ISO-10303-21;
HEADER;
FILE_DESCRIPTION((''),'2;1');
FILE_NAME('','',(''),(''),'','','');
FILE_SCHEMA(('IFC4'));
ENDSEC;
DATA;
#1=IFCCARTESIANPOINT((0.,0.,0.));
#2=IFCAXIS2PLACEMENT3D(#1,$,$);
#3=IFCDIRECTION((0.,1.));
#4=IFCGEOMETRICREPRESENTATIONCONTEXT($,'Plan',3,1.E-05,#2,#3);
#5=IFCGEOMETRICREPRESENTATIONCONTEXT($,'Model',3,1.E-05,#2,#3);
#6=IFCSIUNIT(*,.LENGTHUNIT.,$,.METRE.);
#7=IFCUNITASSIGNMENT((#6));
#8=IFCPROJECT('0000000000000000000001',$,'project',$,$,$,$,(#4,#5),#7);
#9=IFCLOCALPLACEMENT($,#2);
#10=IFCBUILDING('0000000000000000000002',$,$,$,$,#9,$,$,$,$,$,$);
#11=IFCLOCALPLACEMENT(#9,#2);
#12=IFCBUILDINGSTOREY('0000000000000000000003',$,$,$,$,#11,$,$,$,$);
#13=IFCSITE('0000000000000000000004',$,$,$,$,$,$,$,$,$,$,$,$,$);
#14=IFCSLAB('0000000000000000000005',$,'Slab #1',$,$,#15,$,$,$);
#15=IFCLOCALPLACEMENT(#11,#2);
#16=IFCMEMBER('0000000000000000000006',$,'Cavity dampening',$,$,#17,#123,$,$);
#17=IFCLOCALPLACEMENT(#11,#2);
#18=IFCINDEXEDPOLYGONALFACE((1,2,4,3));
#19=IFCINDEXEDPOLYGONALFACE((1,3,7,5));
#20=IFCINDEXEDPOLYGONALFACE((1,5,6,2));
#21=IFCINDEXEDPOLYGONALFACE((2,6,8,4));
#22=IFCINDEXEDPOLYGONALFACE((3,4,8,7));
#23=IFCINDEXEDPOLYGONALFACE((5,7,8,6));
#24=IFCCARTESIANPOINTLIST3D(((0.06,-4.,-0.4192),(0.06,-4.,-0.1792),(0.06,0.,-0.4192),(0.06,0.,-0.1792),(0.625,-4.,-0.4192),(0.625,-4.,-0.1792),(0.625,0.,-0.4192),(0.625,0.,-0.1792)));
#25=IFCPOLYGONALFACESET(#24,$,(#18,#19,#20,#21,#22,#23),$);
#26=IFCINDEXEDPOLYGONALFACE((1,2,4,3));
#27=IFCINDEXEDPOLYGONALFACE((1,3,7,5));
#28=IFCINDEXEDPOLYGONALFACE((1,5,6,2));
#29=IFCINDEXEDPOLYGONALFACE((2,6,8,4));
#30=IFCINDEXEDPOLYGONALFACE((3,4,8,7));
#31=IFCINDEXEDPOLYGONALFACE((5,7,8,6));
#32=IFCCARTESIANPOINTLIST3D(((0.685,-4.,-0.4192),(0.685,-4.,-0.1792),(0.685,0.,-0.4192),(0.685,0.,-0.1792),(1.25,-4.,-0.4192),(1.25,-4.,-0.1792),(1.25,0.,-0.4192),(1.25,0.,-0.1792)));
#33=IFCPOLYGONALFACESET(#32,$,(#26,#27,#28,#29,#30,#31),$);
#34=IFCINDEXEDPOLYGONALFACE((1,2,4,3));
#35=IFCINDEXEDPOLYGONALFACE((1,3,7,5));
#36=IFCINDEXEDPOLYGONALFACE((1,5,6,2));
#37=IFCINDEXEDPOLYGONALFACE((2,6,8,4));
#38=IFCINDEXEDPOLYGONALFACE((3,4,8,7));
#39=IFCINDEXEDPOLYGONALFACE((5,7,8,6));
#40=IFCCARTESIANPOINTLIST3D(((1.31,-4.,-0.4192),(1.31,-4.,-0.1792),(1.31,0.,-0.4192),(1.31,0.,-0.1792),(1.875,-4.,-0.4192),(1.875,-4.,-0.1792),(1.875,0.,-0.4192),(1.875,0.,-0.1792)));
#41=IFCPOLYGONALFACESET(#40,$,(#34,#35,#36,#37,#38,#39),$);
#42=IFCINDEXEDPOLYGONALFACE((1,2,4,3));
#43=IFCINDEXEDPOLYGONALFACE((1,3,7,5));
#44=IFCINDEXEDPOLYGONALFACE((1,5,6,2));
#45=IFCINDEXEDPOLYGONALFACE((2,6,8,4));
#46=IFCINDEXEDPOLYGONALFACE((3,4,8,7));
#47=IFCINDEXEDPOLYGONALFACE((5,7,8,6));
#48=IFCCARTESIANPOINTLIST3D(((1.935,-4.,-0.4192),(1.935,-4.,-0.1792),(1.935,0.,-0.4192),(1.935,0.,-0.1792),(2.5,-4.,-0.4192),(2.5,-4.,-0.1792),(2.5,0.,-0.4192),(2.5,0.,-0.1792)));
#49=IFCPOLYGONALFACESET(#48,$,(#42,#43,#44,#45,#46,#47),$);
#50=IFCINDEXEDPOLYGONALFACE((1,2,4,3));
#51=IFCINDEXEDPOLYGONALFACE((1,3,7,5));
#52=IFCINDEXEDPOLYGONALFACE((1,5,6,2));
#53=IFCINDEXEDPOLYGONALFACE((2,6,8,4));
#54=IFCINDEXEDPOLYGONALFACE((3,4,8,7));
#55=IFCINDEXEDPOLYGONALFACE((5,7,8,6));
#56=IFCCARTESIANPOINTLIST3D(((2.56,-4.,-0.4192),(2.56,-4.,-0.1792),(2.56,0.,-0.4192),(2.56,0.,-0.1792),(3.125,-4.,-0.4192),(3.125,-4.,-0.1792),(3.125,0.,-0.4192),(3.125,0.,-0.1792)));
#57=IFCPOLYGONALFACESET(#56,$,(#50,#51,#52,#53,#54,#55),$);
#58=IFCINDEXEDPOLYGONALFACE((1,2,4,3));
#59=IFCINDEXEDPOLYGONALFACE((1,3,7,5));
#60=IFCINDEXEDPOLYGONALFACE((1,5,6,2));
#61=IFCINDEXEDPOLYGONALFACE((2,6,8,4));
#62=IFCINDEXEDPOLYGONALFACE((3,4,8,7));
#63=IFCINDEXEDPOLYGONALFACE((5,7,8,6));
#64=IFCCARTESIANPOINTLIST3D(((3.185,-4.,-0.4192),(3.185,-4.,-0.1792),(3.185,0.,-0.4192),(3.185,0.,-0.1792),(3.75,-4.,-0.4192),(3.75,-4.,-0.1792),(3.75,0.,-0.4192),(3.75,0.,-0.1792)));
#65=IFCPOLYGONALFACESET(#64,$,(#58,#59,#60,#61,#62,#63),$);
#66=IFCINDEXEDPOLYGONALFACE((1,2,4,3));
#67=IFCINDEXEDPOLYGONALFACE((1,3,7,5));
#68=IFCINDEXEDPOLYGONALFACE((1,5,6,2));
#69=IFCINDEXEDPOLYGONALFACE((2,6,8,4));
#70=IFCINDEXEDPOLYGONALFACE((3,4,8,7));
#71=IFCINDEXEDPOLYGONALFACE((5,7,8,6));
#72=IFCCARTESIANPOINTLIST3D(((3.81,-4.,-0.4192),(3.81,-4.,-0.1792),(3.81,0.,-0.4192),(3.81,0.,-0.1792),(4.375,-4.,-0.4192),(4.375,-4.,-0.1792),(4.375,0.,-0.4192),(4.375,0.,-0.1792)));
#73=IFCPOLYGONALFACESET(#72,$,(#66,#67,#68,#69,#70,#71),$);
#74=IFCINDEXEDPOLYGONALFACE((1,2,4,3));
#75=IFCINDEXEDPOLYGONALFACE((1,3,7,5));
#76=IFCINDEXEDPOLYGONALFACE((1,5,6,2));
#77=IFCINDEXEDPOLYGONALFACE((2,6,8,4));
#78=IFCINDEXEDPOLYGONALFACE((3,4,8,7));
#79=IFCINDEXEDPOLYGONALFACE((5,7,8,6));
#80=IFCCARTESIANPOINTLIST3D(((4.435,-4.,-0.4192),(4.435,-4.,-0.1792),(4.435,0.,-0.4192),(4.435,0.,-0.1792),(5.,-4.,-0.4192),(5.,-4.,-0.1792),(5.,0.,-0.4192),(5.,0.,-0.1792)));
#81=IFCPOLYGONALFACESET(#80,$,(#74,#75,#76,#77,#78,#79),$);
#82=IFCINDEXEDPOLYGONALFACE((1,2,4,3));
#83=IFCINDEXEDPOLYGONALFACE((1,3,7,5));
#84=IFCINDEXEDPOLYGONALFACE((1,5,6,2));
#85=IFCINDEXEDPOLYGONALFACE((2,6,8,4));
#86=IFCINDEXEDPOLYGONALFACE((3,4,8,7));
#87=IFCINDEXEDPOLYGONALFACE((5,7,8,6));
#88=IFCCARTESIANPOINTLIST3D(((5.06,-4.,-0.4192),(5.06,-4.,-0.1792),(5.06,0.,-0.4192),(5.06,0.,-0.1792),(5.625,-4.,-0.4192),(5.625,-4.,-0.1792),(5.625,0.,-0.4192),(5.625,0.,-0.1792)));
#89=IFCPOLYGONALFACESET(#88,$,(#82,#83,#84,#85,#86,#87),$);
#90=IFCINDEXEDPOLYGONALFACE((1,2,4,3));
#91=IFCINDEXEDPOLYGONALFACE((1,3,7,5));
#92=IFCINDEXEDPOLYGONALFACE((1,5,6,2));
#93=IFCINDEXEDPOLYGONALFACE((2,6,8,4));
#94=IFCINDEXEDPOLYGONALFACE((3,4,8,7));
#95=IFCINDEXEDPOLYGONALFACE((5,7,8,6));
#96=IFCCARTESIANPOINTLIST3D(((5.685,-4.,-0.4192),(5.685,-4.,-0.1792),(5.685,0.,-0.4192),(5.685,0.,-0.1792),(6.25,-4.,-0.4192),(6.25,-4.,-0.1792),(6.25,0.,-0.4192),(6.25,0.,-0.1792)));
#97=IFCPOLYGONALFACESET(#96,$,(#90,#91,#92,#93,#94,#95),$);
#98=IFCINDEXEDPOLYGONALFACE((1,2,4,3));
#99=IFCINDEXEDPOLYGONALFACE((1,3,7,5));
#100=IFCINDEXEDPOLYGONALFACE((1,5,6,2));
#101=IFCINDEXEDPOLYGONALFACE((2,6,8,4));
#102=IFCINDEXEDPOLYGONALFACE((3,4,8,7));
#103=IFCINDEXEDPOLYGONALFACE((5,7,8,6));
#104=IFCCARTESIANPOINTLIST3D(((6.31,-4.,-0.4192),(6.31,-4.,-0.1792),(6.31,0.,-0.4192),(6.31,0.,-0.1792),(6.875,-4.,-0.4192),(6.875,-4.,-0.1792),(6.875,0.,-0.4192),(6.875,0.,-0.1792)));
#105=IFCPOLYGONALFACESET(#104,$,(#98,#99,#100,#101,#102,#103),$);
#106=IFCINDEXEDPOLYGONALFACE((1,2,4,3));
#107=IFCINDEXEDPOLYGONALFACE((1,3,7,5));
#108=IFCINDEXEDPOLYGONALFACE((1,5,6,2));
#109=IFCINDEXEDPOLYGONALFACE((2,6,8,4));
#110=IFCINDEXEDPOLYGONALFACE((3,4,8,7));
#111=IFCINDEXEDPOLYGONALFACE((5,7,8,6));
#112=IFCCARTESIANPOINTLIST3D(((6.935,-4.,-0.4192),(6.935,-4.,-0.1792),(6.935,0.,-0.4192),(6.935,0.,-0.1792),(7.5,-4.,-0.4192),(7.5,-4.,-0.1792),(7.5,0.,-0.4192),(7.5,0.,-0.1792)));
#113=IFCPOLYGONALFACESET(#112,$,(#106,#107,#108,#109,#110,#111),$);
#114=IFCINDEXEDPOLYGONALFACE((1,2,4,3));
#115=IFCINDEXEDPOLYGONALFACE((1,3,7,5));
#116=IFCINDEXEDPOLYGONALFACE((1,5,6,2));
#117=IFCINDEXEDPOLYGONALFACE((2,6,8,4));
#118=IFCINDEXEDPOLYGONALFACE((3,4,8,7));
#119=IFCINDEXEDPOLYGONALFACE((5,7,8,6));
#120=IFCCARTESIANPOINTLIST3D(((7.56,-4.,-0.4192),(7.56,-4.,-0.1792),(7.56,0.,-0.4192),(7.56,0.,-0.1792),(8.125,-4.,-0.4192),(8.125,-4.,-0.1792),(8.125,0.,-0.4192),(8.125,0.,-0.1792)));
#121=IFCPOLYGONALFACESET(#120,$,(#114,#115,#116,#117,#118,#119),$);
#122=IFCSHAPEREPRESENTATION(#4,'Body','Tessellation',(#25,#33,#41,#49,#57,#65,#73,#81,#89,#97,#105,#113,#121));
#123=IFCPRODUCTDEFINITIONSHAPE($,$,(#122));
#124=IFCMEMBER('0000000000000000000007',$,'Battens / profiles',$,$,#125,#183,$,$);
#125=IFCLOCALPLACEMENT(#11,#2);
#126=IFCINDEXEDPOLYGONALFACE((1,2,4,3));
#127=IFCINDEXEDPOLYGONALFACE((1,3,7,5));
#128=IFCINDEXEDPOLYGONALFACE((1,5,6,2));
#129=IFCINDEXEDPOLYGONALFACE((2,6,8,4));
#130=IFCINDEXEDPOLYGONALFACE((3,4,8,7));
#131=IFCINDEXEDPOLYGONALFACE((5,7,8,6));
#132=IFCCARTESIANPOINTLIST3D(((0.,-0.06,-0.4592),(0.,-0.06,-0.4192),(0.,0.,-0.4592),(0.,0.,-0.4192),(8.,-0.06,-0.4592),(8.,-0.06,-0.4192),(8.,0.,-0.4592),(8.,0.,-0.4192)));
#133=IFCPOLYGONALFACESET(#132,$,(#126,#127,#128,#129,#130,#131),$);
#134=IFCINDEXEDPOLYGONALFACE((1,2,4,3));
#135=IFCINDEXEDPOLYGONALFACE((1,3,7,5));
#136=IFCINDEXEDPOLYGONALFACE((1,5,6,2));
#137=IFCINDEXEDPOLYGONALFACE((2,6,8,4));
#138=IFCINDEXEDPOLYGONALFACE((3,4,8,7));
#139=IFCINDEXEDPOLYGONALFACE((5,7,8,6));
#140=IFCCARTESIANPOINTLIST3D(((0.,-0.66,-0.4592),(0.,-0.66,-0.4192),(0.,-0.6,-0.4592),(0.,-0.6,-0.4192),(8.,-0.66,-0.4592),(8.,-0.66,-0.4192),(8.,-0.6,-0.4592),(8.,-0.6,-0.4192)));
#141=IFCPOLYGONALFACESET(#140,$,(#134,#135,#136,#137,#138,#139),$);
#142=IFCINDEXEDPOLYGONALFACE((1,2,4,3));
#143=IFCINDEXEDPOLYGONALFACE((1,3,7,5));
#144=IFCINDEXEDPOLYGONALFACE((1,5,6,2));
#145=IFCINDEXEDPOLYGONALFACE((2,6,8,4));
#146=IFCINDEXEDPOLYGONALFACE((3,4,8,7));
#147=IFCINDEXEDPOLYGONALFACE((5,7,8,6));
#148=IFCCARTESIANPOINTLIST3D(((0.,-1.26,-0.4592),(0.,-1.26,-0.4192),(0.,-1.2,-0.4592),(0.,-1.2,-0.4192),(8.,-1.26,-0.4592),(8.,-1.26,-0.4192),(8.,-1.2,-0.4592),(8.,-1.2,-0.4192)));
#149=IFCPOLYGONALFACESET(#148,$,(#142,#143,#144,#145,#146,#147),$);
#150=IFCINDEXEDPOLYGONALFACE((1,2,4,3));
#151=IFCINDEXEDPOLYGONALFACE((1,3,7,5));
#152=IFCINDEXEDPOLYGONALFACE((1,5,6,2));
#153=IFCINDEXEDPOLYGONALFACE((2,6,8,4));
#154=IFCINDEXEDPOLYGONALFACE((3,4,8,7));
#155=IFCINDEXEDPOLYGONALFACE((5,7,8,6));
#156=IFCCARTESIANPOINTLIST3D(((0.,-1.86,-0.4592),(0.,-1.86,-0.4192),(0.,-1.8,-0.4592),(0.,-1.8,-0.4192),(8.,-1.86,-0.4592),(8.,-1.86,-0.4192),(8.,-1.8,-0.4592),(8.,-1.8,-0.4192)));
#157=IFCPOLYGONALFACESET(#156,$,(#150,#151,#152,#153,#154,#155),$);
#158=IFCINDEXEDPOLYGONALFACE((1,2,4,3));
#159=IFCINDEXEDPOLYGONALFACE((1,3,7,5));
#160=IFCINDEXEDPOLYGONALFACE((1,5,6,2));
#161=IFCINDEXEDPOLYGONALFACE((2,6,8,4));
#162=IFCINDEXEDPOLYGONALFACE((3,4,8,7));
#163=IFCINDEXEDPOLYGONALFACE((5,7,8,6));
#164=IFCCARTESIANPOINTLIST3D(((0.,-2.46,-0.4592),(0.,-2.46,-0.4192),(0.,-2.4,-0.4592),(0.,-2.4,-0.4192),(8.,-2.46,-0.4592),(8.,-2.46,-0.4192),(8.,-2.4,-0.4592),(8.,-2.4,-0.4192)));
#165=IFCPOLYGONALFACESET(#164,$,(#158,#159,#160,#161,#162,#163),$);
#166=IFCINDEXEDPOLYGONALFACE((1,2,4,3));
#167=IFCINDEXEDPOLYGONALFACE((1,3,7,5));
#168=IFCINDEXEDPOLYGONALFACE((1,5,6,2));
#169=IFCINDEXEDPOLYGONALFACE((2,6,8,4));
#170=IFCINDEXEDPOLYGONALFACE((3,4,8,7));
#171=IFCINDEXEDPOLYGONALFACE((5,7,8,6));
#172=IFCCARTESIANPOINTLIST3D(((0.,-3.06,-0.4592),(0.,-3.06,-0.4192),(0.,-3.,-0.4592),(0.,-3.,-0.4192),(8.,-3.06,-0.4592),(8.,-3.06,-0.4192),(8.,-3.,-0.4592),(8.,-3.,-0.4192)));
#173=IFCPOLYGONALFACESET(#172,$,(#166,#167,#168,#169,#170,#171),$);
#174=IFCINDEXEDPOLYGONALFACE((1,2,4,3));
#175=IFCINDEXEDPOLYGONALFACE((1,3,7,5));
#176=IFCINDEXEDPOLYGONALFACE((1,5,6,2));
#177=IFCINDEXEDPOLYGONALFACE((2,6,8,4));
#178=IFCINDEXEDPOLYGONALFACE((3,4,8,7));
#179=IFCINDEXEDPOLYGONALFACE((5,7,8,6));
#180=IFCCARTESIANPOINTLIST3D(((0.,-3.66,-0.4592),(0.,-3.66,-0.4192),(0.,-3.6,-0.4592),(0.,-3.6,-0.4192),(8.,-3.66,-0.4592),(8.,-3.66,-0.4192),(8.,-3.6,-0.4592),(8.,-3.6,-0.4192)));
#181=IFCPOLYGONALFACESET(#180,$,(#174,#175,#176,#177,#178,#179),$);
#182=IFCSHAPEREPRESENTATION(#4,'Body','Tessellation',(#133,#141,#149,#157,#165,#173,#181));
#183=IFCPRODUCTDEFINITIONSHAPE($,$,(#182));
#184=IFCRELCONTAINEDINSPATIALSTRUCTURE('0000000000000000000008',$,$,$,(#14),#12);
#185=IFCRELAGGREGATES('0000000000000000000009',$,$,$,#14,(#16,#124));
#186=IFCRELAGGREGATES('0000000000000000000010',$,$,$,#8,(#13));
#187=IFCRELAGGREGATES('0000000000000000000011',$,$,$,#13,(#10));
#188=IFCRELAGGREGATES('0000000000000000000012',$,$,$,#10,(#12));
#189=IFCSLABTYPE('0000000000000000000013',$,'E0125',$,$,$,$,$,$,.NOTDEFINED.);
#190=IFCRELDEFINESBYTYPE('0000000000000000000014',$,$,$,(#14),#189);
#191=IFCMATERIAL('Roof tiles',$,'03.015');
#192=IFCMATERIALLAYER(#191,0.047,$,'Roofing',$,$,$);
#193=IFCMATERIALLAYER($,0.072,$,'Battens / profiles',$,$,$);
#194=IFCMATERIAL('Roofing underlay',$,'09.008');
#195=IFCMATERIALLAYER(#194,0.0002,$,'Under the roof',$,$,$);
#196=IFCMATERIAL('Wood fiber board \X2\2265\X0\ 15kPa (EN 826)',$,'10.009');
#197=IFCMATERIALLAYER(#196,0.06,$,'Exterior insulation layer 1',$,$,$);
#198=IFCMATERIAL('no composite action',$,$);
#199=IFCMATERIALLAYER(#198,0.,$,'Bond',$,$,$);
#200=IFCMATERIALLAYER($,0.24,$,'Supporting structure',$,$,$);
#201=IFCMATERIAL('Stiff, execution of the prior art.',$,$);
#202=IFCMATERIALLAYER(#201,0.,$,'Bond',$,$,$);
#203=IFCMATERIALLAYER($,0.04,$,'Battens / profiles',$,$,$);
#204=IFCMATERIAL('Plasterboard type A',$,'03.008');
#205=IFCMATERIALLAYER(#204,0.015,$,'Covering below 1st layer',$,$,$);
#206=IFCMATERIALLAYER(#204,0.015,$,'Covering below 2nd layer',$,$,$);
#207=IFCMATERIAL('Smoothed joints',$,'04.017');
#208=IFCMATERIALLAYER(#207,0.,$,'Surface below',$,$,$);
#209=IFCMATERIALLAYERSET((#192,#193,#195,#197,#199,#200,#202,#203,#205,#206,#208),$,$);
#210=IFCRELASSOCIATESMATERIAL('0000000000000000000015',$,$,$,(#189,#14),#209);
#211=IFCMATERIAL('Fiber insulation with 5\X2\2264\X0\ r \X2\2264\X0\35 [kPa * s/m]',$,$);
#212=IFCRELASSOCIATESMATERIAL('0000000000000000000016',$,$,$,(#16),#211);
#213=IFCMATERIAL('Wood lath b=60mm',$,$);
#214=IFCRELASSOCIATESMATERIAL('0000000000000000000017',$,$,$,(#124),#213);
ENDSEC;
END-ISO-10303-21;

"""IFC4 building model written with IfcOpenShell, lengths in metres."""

from ifc_helpers import new_model, si_unit, direction, frame, frame_2d, origin, place, context, project, spatial, rectangle, extrude, material, layer, layer_set, type_object, element, aggregate, save


model = new_model("IFC4")

# Units and contexts
plan_context = context("Plan", 3, precision=1e-05, world=origin(), true_north=direction((0.0, 1.0)))
model_context = context("Model", 3, precision=1e-05, world=origin(), true_north=direction((0.0, 1.0)))
ifc_project = project(units=[si_unit("LENGTHUNIT", "METRE")], contexts=[plan_context, model_context])

# Site, building, storey
site = spatial("IfcSite", under=ifc_project)
building_placement = place(None, origin())
building = spatial("IfcBuilding", under=site, at=building_placement)
storey_placement = place(building_placement, origin())
storey = spatial("IfcBuildingStorey", under=building, at=storey_placement)

# Slab, members
ifc_material_1 = material(Name="Roof tiles", Category="03.015")
ifc_layer_1 = layer(ifc_material_1, 0.047, Name="Roofing")
ifc_layer_2 = layer(None, 0.072, Name="Battens / profiles")
ifc_material_2 = material(Name="Roofing underlay", Category="09.008")
ifc_layer_3 = layer(ifc_material_2, 0.0002, Name="Under the roof")
ifc_material_3 = material(Name="Wood fiber board ≥ 15kPa (EN 826)", Category="10.009")
ifc_layer_4 = layer(ifc_material_3, 0.06, Name="Exterior insulation layer 1")
ifc_material_4 = material(Name="no composite action")
ifc_layer_5 = layer(ifc_material_4, 0.0, Name="Bond")
ifc_layer_6 = layer(None, 0.24, Name="Supporting structure")
ifc_material_5 = material(Name="Stiff, execution of the prior art.")
ifc_layer_7 = layer(ifc_material_5, 0.0, Name="Bond")
ifc_layer_8 = layer(None, 0.04, Name="Battens / profiles")
ifc_material_6 = material(Name="Plasterboard type A", Category="03.008")
ifc_layer_9 = layer(ifc_material_6, 0.015, Name="Covering below 1st layer")
ifc_layer_10 = layer(ifc_material_6, 0.015, Name="Covering below 2nd layer")
ifc_material_7 = material(Name="Smoothed joints", Category="04.017")
ifc_layer_11 = layer(ifc_material_7, 0.0, Name="Surface below")
ifc_layer_set = layer_set([ifc_layer_1, ifc_layer_2, ifc_layer_3, ifc_layer_4, ifc_layer_5, ifc_layer_6, ifc_layer_7, ifc_layer_8, ifc_layer_9, ifc_layer_10, ifc_layer_11])
slab_type = type_object("IfcSlabType", Name="E0125", PredefinedType="NOTDEFINED", material=ifc_layer_set)
slab_placement = place(None, frame((0.0, 0.0, 0.0), z_axis=(0.0, 0.0, -1.0), x_axis=(1.0, 0.0, 0.0)))
slab = element("IfcSlab", 1, at=slab_placement, inside=storey, type_object=slab_type, material=ifc_layer_set, Name="Slab #1")
ifc_material_8 = material(Name="Fiber insulation with 5≤ r ≤35 [kPa * s/m]")
member_1_placement = place(slab_placement, origin())
member_1 = element("IfcMember", 2, at=member_1_placement, material=ifc_material_8, Name="Cavity dampening", context=plan_context, shape_type="SweptSolid", body=[
    extrude(rectangle(XDim=0.565, YDim=0.24, at=frame_2d((0.2825, 0.12), x_axis=(1.0, 0.0))), frame((0.06, 4.0, 0.1792), z_axis=(0.0, -1.0, 0.0), x_axis=(1.0, 0.0, 0.0)), (0.0, 0.0, 1.0), 4.0),
    extrude(rectangle(XDim=0.565, YDim=0.24, at=frame_2d((0.2825, 0.12), x_axis=(1.0, 0.0))), frame((0.685, 4.0, 0.1792), z_axis=(0.0, -1.0, 0.0), x_axis=(1.0, 0.0, 0.0)), (0.0, 0.0, 1.0), 4.0),
    extrude(rectangle(XDim=0.565, YDim=0.24, at=frame_2d((0.2825, 0.12), x_axis=(1.0, 0.0))), frame((1.31, 4.0, 0.1792), z_axis=(0.0, -1.0, 0.0), x_axis=(1.0, 0.0, 0.0)), (0.0, 0.0, 1.0), 4.0),
    extrude(rectangle(XDim=0.565, YDim=0.24, at=frame_2d((0.2825, 0.12), x_axis=(1.0, 0.0))), frame((1.935, 4.0, 0.1792), z_axis=(0.0, -1.0, 0.0), x_axis=(1.0, 0.0, 0.0)), (0.0, 0.0, 1.0), 4.0),
    extrude(rectangle(XDim=0.565, YDim=0.24, at=frame_2d((0.2825, 0.12), x_axis=(1.0, 0.0))), frame((2.56, 4.0, 0.1792), z_axis=(0.0, -1.0, 0.0), x_axis=(1.0, 0.0, 0.0)), (0.0, 0.0, 1.0), 4.0),
    extrude(rectangle(XDim=0.565, YDim=0.24, at=frame_2d((0.2825, 0.12), x_axis=(1.0, 0.0))), frame((3.185, 4.0, 0.1792), z_axis=(0.0, -1.0, 0.0), x_axis=(1.0, 0.0, 0.0)), (0.0, 0.0, 1.0), 4.0),
    extrude(rectangle(XDim=0.565, YDim=0.24, at=frame_2d((0.2825, 0.12), x_axis=(1.0, 0.0))), frame((3.81, 4.0, 0.1792), z_axis=(0.0, -1.0, 0.0), x_axis=(1.0, 0.0, 0.0)), (0.0, 0.0, 1.0), 4.0),
    extrude(rectangle(XDim=0.565, YDim=0.24, at=frame_2d((0.2825, 0.12), x_axis=(1.0, 0.0))), frame((4.435, 4.0, 0.1792), z_axis=(0.0, -1.0, 0.0), x_axis=(1.0, 0.0, 0.0)), (0.0, 0.0, 1.0), 4.0),
    extrude(rectangle(XDim=0.565, YDim=0.24, at=frame_2d((0.2825, 0.12), x_axis=(1.0, 0.0))), frame((5.06, 4.0, 0.1792), z_axis=(0.0, -1.0, 0.0), x_axis=(1.0, 0.0, 0.0)), (0.0, 0.0, 1.0), 4.0),
    extrude(rectangle(XDim=0.565, YDim=0.24, at=frame_2d((0.2825, 0.12), x_axis=(1.0, 0.0))), frame((5.685, 4.0, 0.1792), z_axis=(0.0, -1.0, 0.0), x_axis=(1.0, 0.0, 0.0)), (0.0, 0.0, 1.0), 4.0),
    extrude(rectangle(XDim=0.565, YDim=0.24, at=frame_2d((0.2825, 0.12), x_axis=(1.0, 0.0))), frame((6.31, 4.0, 0.1792), z_axis=(0.0, -1.0, 0.0), x_axis=(1.0, 0.0, 0.0)), (0.0, 0.0, 1.0), 4.0),
    extrude(rectangle(XDim=0.565, YDim=0.24, at=frame_2d((0.2825, 0.12), x_axis=(1.0, 0.0))), frame((6.935, 4.0, 0.1792), z_axis=(0.0, -1.0, 0.0), x_axis=(1.0, 0.0, 0.0)), (0.0, 0.0, 1.0), 4.0),
    extrude(rectangle(XDim=0.565, YDim=0.24, at=frame_2d((0.2825, 0.12), x_axis=(1.0, 0.0))), frame((7.56, 4.0, 0.1792), z_axis=(0.0, -1.0, 0.0), x_axis=(1.0, 0.0, 0.0)), (0.0, 0.0, 1.0), 4.0),
])
ifc_material_9 = material(Name="Wood lath b=60mm")
member_2_placement = place(slab_placement, origin())
member_2 = element("IfcMember", 3, at=member_2_placement, material=ifc_material_9, Name="Battens / profiles", context=plan_context, shape_type="SweptSolid", body=[
    extrude(rectangle(XDim=0.06, YDim=0.04, at=frame_2d((0.03, 0.02), x_axis=(1.0, 0.0))), frame((0.0, 0.0, 0.4192), z_axis=(1.0, 0.0, 0.0), x_axis=(0.0, 1.0, 0.0)), (0.0, 0.0, 1.0), 8.0),
    extrude(rectangle(XDim=0.06, YDim=0.04, at=frame_2d((0.03, 0.02), x_axis=(1.0, 0.0))), frame((0.0, 0.6, 0.4192), z_axis=(1.0, 0.0, 0.0), x_axis=(0.0, 1.0, 0.0)), (0.0, 0.0, 1.0), 8.0),
    extrude(rectangle(XDim=0.06, YDim=0.04, at=frame_2d((0.03, 0.02), x_axis=(1.0, 0.0))), frame((0.0, 1.2, 0.4192), z_axis=(1.0, 0.0, 0.0), x_axis=(0.0, 1.0, 0.0)), (0.0, 0.0, 1.0), 8.0),
    extrude(rectangle(XDim=0.06, YDim=0.04, at=frame_2d((0.03, 0.02), x_axis=(1.0, 0.0))), frame((0.0, 1.8, 0.4192), z_axis=(1.0, 0.0, 0.0), x_axis=(0.0, 1.0, 0.0)), (0.0, 0.0, 1.0), 8.0),
    extrude(rectangle(XDim=0.06, YDim=0.04, at=frame_2d((0.03, 0.02), x_axis=(1.0, 0.0))), frame((0.0, 2.4, 0.4192), z_axis=(1.0, 0.0, 0.0), x_axis=(0.0, 1.0, 0.0)), (0.0, 0.0, 1.0), 8.0),
    extrude(rectangle(XDim=0.06, YDim=0.04, at=frame_2d((0.03, 0.02), x_axis=(1.0, 0.0))), frame((0.0, 3.0, 0.4192), z_axis=(1.0, 0.0, 0.0), x_axis=(0.0, 1.0, 0.0)), (0.0, 0.0, 1.0), 8.0),
    extrude(rectangle(XDim=0.06, YDim=0.04, at=frame_2d((0.03, 0.02), x_axis=(1.0, 0.0))), frame((0.0, 3.6, 0.4192), z_axis=(1.0, 0.0, 0.0), x_axis=(0.0, 1.0, 0.0)), (0.0, 0.0, 1.0), 8.0),
])
aggregate(slab, [member_1, member_2])

save(model, "model.ifc")
